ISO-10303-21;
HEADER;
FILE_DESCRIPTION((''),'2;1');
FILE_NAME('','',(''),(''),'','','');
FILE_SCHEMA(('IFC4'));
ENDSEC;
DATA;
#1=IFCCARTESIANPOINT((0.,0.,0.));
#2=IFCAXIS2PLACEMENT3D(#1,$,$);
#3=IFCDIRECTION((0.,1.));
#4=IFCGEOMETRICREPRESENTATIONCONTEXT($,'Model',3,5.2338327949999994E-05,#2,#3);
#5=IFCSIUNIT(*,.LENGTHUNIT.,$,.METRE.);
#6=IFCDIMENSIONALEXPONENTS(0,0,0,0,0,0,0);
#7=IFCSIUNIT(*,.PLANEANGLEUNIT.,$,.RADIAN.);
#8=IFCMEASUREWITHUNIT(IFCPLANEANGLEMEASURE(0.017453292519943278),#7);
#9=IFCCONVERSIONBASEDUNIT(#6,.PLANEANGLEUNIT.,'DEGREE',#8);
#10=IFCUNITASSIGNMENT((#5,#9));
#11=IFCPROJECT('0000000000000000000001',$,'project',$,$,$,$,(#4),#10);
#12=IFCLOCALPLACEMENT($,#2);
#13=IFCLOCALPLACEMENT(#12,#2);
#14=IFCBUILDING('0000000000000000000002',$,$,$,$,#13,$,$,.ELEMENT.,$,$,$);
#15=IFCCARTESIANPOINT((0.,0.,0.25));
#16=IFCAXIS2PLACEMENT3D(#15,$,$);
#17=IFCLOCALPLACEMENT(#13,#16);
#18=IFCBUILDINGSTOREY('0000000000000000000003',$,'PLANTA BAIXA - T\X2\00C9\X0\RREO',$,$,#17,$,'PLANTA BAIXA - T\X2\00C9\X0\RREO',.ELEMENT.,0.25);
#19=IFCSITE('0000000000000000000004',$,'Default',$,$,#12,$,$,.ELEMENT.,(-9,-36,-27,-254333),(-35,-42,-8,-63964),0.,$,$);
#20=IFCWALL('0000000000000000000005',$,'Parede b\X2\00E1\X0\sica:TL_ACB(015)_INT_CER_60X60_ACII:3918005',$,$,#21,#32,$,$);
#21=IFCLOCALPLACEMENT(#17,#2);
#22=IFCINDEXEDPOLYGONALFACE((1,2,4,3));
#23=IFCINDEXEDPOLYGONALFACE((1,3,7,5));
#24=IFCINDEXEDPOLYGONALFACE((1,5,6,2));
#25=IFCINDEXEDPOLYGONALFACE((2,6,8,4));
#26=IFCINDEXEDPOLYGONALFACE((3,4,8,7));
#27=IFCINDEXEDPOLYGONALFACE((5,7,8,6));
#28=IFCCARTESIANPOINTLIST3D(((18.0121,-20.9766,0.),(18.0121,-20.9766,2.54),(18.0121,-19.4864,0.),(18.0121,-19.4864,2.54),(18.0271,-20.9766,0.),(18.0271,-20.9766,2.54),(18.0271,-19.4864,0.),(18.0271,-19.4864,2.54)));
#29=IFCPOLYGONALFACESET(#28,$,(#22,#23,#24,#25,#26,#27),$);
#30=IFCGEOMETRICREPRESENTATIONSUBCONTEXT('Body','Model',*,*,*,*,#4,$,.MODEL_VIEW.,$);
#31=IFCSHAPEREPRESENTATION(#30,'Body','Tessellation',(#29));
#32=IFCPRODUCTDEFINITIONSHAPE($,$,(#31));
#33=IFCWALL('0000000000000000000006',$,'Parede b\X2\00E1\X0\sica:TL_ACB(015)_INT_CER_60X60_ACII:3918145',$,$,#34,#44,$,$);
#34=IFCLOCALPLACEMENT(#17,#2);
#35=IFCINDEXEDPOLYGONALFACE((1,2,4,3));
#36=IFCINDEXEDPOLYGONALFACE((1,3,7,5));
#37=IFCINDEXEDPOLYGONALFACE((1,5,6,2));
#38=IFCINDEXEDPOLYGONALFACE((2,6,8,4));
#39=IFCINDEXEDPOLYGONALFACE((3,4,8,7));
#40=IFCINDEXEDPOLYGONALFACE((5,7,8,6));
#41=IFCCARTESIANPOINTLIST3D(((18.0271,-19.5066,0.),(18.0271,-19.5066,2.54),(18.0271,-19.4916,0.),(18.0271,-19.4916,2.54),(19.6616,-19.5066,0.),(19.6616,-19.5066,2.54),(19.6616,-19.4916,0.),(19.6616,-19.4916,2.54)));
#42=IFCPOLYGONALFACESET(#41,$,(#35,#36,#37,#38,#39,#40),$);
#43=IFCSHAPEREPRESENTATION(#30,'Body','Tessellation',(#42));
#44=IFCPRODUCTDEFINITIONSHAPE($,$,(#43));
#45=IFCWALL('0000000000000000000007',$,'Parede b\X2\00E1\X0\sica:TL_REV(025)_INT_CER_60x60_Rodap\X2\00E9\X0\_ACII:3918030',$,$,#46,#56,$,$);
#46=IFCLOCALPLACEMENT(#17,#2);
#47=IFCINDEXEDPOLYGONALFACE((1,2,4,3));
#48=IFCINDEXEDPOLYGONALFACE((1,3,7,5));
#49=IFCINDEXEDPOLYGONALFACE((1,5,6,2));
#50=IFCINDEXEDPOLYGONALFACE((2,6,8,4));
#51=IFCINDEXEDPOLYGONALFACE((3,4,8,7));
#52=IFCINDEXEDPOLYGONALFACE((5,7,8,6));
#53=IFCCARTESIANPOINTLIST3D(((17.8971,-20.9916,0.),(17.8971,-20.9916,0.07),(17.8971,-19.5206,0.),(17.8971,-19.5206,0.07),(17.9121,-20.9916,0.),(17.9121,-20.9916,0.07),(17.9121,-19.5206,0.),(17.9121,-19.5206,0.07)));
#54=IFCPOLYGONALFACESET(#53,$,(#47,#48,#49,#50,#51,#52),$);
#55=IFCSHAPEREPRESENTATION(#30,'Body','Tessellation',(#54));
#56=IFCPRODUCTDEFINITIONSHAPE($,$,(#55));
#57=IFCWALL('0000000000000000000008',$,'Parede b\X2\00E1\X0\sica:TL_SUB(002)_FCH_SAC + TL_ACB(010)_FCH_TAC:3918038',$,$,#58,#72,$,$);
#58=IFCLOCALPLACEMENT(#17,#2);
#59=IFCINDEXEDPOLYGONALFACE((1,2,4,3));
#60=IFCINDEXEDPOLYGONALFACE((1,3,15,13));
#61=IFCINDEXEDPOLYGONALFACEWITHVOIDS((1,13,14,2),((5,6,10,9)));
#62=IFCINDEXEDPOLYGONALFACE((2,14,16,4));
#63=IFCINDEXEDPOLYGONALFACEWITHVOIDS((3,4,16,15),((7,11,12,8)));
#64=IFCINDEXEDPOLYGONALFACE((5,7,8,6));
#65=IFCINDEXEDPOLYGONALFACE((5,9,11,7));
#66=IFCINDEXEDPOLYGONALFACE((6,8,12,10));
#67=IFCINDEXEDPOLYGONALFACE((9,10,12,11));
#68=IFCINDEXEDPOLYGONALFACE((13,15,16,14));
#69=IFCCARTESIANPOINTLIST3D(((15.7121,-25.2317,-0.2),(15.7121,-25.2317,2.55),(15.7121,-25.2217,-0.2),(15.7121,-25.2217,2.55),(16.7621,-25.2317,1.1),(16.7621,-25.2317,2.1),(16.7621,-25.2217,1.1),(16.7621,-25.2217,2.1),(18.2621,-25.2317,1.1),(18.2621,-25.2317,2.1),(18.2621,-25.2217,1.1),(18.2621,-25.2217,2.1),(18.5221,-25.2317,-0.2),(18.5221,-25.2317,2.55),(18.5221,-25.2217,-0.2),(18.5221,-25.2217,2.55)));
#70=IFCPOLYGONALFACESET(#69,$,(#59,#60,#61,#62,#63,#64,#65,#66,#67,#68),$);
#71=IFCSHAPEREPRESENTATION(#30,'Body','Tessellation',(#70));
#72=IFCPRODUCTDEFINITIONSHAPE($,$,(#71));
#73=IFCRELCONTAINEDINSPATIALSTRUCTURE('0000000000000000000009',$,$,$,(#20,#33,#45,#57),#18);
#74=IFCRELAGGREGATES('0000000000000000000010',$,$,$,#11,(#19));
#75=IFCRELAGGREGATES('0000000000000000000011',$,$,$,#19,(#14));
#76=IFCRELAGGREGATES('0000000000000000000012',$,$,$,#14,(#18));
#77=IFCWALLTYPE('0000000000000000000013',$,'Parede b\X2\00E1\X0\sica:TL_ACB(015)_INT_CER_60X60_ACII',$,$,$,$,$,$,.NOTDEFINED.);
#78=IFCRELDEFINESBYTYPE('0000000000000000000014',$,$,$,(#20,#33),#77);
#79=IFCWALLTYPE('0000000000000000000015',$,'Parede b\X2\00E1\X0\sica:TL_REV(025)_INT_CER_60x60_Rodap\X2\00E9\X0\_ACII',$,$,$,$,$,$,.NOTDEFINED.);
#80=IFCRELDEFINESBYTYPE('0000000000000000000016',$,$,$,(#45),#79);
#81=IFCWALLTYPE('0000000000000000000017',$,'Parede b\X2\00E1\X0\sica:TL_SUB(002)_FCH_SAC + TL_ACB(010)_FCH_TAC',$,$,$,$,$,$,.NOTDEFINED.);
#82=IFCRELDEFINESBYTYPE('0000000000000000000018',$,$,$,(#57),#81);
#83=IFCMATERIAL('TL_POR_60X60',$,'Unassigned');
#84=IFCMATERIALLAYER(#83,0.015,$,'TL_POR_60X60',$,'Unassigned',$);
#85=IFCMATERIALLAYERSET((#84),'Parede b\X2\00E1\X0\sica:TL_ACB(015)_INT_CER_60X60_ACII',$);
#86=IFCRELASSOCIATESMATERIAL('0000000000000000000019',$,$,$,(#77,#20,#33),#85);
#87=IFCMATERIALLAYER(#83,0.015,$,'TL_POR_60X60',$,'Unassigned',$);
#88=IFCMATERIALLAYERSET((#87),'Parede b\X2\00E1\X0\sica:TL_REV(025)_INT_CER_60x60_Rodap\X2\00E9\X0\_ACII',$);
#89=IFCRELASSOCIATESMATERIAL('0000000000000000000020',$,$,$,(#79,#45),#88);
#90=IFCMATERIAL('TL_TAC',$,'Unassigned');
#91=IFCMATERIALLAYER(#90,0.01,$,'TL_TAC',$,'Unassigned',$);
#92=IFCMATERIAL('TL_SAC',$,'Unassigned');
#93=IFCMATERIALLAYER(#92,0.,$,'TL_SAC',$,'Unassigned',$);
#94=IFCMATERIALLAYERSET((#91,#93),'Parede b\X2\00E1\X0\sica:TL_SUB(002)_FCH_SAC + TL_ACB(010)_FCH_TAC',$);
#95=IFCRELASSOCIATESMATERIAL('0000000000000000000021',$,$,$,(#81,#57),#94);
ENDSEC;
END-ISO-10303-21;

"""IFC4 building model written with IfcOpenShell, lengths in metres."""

from ifc_helpers import new_model, entity, si_unit, converted_unit, direction, frame, frame_2d, origin, place, context, subcontext, project, spatial, rectangle, extrude, material, layer, layer_set, layer_usage, type_object, element, save


model = new_model("IFC4")

# Units and contexts
model_context = context("Model", 3, precision=5.2338327949999994e-05, world=origin(), true_north=direction((0.0, 1.0)))
body_context = subcontext(model_context, "Body", "Model", "MODEL_VIEW")
ifc_project = project(units=[si_unit("LENGTHUNIT", "METRE"), converted_unit("PLANEANGLEUNIT", "DEGREE", entity("IfcPlaneAngleMeasure", 0.017453292519943278), si_unit("PLANEANGLEUNIT", "RADIAN"), dimensions=[0, 0, 0, 0, 0, 0, 0])], contexts=[model_context])

# Site, building, storey
site_placement = place(None, frame((0.0, 0.0, 0.0)))
site = spatial("IfcSite", under=ifc_project, at=site_placement, Name="Default", CompositionType="ELEMENT", RefLatitude=(-9, -36, -27, -254333), RefLongitude=(-35, -42, -8, -63964), RefElevation=0.0)
building_placement = place(site_placement, origin())
building = spatial("IfcBuilding", under=site, at=building_placement, CompositionType="ELEMENT")
storey_placement = place(building_placement, frame((0.0, 0.0, 0.25)))
storey = spatial("IfcBuildingStorey", under=building, at=storey_placement, Name="PLANTA BAIXA - TÉRREO", LongName="PLANTA BAIXA - TÉRREO", CompositionType="ELEMENT", Elevation=0.25)

# Shared definitions
ifc_material_1 = material(Name="TL_SAC", Category="Unassigned")

# Walls
ifc_material_2 = material(Name="TL_POR_60X60", Category="Unassigned")
ifc_layer_1 = layer(ifc_material_2, 0.015, Name="TL_POR_60X60", Category="Unassigned")
ifc_layer_set_1 = layer_set([ifc_layer_1], Name="Parede básica:TL_ACB(015)_INT_CER_60X60_ACII")
ifc_layer_usage_1 = layer_usage(ifc_layer_set_1, "AXIS2", "NEGATIVE", 0.0075)
wall_type_1 = type_object("IfcWallType", Name="Parede básica:TL_ACB(015)_INT_CER_60X60_ACII", PredefinedType="NOTDEFINED", material=ifc_layer_set_1)
wall_1_placement = place(storey_placement, frame((18.0196, -19.4864, 0.0), z_axis=(0.0, 0.0, 1.0), x_axis=(0.0, -1.0, 0.0)))
element("IfcWall", 1, at=wall_1_placement, inside=storey, type_object=wall_type_1, material=ifc_layer_usage_1, Name="Parede básica:TL_ACB(015)_INT_CER_60X60_ACII:3918005", context=body_context, shape_type="SweptSolid", body=[
    extrude(rectangle(XDim=1.4902, YDim=0.015, at=frame_2d((0.7451, 0.0), x_axis=(-1.0, 0.0))), origin(), (0.0, 0.0, 1.0), 2.54),
])
ifc_layer_usage_2 = layer_usage(ifc_layer_set_1, "AXIS2", "POSITIVE", -0.0075)
wall_2_placement = place(storey_placement, frame((18.0271, -19.4991, 0.0)))
element("IfcWall", 2, at=wall_2_placement, inside=storey, type_object=wall_type_1, material=ifc_layer_usage_2, Name="Parede básica:TL_ACB(015)_INT_CER_60X60_ACII:3918145", context=body_context, shape_type="SweptSolid", body=[
    extrude(rectangle(XDim=1.6345, YDim=0.015, at=frame_2d((0.8172, 0.0), x_axis=(-1.0, 0.0))), origin(), (0.0, 0.0, 1.0), 2.54),
])
ifc_layer_2 = layer(ifc_material_2, 0.015, Name="TL_POR_60X60", Category="Unassigned")
ifc_layer_set_2 = layer_set([ifc_layer_2], Name="Parede básica:TL_REV(025)_INT_CER_60x60_Rodapé_ACII")
ifc_layer_usage_3 = layer_usage(ifc_layer_set_2, "AXIS2", "POSITIVE", -0.0075)
wall_type_2 = type_object("IfcWallType", Name="Parede básica:TL_REV(025)_INT_CER_60x60_Rodapé_ACII", PredefinedType="NOTDEFINED", material=ifc_layer_set_2)
wall_3_placement = place(storey_placement, frame((17.9046, -19.5206, 0.0), z_axis=(0.0, 0.0, 1.0), x_axis=(0.0, -1.0, 0.0)))
element("IfcWall", 3, at=wall_3_placement, inside=storey, type_object=wall_type_2, material=ifc_layer_usage_3, Name="Parede básica:TL_REV(025)_INT_CER_60x60_Rodapé_ACII:3918030", context=body_context, shape_type="SweptSolid", body=[
    extrude(rectangle(XDim=1.471, YDim=0.015, at=frame_2d((0.7355, 0.0), x_axis=(-1.0, 0.0))), origin(), (0.0, 0.0, 1.0), 0.07),
])

# Wall, opening
ifc_material_3 = material(Name="TL_TAC", Category="Unassigned")
ifc_layer_3 = layer(ifc_material_3, 0.01, Name="TL_TAC", Category="Unassigned")
ifc_layer_4 = layer(ifc_material_1, 0.0, Name="TL_SAC", Category="Unassigned")
ifc_layer_set_3 = layer_set([ifc_layer_3, ifc_layer_4], Name="Parede básica:TL_SUB(002)_FCH_SAC + TL_ACB(010)_FCH_TAC")
ifc_layer_usage_4 = layer_usage(ifc_layer_set_3, "AXIS2", "POSITIVE", -0.005)
wall_type_3 = type_object("IfcWallType", Name="Parede básica:TL_SUB(002)_FCH_SAC + TL_ACB(010)_FCH_TAC", PredefinedType="NOTDEFINED", material=ifc_layer_set_3)
wall_4_placement = place(storey_placement, frame((15.7121, -25.2267, -0.2)))
wall_4 = element("IfcWall", 4, at=wall_4_placement, inside=storey, type_object=wall_type_3, material=ifc_layer_usage_4, Name="Parede básica:TL_SUB(002)_FCH_SAC + TL_ACB(010)_FCH_TAC:3918038", context=body_context, shape_type="SweptSolid", body=[
    extrude(rectangle(XDim=2.81, YDim=0.01, at=frame_2d((1.405, 0.0), x_axis=(-1.0, 0.0))), origin(), (0.0, 0.0, 1.0), 2.75),
])
opening_1_placement = place(wall_4_placement, frame((-15.7121, 25.2267, 1.3)))
element("IfcOpeningElement", 5, at=opening_1_placement, cuts=wall_4, PredefinedType="OPENING", context=body_context, shape_type="SweptSolid", body=[
    extrude(rectangle(XDim=1.0, YDim=1.5, at=frame_2d((0.0, 0.0), x_axis=(0.0, 1.0))), frame((17.5121, -26.6457, 0.5), z_axis=(0.0, 1.0, 0.0), x_axis=(1.0, 0.0, 0.0)), (0.0, 0.0, 1.0), 3.048),
])

save(model, "model.ifc")
